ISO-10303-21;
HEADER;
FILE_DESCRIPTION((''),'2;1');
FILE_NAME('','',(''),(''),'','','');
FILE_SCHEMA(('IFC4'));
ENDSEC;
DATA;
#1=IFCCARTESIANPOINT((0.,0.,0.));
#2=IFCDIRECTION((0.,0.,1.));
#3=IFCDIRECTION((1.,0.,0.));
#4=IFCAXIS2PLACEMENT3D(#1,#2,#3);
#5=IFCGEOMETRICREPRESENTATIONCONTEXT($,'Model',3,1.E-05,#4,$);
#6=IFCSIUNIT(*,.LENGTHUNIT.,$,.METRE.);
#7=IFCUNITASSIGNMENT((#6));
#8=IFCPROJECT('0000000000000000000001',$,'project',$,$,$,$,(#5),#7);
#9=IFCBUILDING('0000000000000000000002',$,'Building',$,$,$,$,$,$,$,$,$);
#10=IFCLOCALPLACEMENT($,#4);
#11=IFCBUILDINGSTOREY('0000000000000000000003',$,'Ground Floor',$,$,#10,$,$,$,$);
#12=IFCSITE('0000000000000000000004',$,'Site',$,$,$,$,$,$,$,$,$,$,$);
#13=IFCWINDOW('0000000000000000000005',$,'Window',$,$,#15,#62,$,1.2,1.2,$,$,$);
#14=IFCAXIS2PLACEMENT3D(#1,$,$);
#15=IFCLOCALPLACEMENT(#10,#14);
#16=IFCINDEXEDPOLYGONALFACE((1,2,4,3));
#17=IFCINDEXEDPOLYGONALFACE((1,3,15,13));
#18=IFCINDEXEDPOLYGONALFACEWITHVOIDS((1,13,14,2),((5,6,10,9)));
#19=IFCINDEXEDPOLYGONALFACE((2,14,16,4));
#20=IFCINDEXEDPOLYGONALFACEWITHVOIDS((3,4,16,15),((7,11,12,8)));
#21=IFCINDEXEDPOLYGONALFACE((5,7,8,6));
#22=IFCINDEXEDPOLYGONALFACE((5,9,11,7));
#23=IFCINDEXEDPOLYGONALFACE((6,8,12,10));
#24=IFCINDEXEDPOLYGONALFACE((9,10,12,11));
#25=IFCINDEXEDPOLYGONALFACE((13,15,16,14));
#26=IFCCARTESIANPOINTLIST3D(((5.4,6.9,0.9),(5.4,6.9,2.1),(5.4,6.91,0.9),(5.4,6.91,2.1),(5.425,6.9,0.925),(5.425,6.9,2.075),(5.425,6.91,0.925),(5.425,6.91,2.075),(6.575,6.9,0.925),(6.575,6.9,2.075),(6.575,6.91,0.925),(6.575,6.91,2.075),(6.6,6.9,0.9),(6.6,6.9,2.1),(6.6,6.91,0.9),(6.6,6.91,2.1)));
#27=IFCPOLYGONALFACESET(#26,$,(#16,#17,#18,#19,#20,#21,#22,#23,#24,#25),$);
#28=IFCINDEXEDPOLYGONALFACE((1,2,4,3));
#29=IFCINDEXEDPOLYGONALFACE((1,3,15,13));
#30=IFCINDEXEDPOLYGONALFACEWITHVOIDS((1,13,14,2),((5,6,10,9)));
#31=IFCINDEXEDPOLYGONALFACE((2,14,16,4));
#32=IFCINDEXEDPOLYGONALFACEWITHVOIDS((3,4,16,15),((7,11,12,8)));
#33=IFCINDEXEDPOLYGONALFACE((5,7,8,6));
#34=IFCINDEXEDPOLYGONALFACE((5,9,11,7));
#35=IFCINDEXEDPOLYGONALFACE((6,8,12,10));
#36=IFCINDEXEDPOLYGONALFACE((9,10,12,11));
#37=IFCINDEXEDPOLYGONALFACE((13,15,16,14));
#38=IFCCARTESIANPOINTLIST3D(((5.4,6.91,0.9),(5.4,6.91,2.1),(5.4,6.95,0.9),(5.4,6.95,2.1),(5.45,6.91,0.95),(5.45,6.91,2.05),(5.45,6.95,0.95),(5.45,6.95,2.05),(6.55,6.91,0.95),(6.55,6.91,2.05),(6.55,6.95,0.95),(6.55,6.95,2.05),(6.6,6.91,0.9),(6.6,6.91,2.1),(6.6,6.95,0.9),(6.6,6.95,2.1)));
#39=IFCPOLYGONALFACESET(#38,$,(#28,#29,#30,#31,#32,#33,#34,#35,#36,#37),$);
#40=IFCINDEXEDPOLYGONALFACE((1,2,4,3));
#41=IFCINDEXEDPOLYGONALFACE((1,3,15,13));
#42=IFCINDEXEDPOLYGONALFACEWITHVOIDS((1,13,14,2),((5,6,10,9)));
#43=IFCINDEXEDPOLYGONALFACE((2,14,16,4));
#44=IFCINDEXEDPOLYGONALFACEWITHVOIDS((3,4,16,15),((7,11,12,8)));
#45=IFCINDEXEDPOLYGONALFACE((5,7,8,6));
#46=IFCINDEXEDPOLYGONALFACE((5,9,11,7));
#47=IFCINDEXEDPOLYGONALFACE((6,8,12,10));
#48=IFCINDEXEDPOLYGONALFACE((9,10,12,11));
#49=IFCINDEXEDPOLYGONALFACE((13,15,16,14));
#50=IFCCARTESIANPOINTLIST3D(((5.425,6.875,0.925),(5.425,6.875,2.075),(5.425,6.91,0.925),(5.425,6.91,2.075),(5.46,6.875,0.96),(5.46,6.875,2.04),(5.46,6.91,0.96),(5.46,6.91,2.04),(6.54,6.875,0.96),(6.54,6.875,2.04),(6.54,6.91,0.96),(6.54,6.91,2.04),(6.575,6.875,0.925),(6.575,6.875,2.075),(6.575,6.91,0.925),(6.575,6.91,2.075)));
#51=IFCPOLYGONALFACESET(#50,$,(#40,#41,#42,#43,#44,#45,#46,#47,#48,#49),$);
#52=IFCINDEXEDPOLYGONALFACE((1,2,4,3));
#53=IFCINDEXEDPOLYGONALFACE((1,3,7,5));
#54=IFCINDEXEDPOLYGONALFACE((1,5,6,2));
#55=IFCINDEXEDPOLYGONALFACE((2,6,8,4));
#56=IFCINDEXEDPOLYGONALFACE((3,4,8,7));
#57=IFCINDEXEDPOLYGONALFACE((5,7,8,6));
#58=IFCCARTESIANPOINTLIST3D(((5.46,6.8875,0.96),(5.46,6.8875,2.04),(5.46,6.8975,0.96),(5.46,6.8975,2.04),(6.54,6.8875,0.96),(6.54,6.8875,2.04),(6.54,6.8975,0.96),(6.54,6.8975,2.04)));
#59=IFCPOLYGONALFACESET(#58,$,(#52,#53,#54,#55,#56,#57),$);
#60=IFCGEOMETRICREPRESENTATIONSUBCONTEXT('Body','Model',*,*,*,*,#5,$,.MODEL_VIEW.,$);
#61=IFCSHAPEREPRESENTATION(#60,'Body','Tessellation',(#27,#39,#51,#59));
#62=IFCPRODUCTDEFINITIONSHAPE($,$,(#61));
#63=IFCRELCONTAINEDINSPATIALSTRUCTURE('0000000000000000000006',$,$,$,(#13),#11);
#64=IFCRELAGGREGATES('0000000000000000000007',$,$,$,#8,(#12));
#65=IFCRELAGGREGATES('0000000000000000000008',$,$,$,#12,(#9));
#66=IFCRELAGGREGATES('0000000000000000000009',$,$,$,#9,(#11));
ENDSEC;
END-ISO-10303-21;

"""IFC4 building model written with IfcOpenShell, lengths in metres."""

from ifc_helpers import new_model, si_unit, frame, origin_with_axes, place, context, subcontext, project, spatial, line, indexed_curve, outline, extrude, element, save


model = new_model("IFC4")

# Units and contexts
model_context = context("Model", 3, precision=1e-05, world=origin_with_axes())
body_context = subcontext(model_context, "Body", "Model", "MODEL_VIEW")
ifc_project = project(units=[si_unit("LENGTHUNIT", "METRE")], contexts=[model_context])

# Site, building, storey
site = spatial("IfcSite", under=ifc_project, Name="Site")
building = spatial("IfcBuilding", under=site, Name="Building")
storey_placement = place(None, origin_with_axes())
storey = spatial("IfcBuildingStorey", under=building, at=storey_placement, Name="Ground Floor")

# Window
for number, where, z_axis, x_axis, name in (
    (1, (6.6, 7.0, 0.9), (0.0, 0.0, 1.0), (-1.0, 0.0, 0.0), "Window"),
):
    element("IfcWindow", number, at=place(storey_placement, frame(where, z_axis=z_axis, x_axis=x_axis)), inside=storey, Name=name, OverallHeight=1.2, OverallWidth=1.2, context=body_context, shape_type="SweptSolid", body=[
        extrude(outline(indexed_curve([(0.0, 0.0), (1.2, 0.0), (1.2, 1.2), (0.0, 1.2)], segments=[line(1, 2, 3, 4, 1)]), holes=[indexed_curve([(0.025, 0.025), (1.175, 0.025), (1.175, 1.175), (0.025, 1.175)], segments=[line(1, 2, 3, 4, 1)])]), frame((0.0, 0.09, 0.0), z_axis=(0.0, -1.0, 0.0), x_axis=(1.0, 0.0, 0.0)), (0.0, 0.0, -1.0), 0.01),
        extrude(outline(indexed_curve([(0.0, 0.0), (1.2, 0.0), (1.2, 1.2), (0.0, 1.2)], segments=[line(1, 2, 3, 4, 1)]), holes=[indexed_curve([(0.05, 0.05), (1.15, 0.05), (1.15, 1.15), (0.05, 1.15)], segments=[line(1, 2, 3, 4, 1)])]), frame((0.0, 0.05, 0.0), z_axis=(0.0, -1.0, 0.0), x_axis=(1.0, 0.0, 0.0)), (0.0, 0.0, -1.0), 0.04),
        extrude(outline(indexed_curve([(0.0, 0.0), (1.15, 0.0), (1.15, 1.15), (0.0, 1.15)], segments=[line(1, 2, 3, 4, 1)]), holes=[indexed_curve([(0.035, 0.035), (1.115, 0.035), (1.115, 1.115), (0.035, 1.115)], segments=[line(1, 2, 3, 4, 1)])]), frame((0.025, 0.09, 0.025), z_axis=(0.0, -1.0, 0.0), x_axis=(1.0, 0.0, 0.0)), (0.0, 0.0, -1.0), 0.035),
        extrude(outline(indexed_curve([(0.035, 0.035), (1.115, 0.035), (1.115, 1.115), (0.035, 1.115)], segments=[line(1, 2, 3, 4, 1)])), frame((0.025, 0.1025, 0.025), z_axis=(0.0, -1.0, 0.0), x_axis=(1.0, 0.0, 0.0)), (0.0, 0.0, -1.0), 0.01),
    ])

save(model, "model.ifc")
